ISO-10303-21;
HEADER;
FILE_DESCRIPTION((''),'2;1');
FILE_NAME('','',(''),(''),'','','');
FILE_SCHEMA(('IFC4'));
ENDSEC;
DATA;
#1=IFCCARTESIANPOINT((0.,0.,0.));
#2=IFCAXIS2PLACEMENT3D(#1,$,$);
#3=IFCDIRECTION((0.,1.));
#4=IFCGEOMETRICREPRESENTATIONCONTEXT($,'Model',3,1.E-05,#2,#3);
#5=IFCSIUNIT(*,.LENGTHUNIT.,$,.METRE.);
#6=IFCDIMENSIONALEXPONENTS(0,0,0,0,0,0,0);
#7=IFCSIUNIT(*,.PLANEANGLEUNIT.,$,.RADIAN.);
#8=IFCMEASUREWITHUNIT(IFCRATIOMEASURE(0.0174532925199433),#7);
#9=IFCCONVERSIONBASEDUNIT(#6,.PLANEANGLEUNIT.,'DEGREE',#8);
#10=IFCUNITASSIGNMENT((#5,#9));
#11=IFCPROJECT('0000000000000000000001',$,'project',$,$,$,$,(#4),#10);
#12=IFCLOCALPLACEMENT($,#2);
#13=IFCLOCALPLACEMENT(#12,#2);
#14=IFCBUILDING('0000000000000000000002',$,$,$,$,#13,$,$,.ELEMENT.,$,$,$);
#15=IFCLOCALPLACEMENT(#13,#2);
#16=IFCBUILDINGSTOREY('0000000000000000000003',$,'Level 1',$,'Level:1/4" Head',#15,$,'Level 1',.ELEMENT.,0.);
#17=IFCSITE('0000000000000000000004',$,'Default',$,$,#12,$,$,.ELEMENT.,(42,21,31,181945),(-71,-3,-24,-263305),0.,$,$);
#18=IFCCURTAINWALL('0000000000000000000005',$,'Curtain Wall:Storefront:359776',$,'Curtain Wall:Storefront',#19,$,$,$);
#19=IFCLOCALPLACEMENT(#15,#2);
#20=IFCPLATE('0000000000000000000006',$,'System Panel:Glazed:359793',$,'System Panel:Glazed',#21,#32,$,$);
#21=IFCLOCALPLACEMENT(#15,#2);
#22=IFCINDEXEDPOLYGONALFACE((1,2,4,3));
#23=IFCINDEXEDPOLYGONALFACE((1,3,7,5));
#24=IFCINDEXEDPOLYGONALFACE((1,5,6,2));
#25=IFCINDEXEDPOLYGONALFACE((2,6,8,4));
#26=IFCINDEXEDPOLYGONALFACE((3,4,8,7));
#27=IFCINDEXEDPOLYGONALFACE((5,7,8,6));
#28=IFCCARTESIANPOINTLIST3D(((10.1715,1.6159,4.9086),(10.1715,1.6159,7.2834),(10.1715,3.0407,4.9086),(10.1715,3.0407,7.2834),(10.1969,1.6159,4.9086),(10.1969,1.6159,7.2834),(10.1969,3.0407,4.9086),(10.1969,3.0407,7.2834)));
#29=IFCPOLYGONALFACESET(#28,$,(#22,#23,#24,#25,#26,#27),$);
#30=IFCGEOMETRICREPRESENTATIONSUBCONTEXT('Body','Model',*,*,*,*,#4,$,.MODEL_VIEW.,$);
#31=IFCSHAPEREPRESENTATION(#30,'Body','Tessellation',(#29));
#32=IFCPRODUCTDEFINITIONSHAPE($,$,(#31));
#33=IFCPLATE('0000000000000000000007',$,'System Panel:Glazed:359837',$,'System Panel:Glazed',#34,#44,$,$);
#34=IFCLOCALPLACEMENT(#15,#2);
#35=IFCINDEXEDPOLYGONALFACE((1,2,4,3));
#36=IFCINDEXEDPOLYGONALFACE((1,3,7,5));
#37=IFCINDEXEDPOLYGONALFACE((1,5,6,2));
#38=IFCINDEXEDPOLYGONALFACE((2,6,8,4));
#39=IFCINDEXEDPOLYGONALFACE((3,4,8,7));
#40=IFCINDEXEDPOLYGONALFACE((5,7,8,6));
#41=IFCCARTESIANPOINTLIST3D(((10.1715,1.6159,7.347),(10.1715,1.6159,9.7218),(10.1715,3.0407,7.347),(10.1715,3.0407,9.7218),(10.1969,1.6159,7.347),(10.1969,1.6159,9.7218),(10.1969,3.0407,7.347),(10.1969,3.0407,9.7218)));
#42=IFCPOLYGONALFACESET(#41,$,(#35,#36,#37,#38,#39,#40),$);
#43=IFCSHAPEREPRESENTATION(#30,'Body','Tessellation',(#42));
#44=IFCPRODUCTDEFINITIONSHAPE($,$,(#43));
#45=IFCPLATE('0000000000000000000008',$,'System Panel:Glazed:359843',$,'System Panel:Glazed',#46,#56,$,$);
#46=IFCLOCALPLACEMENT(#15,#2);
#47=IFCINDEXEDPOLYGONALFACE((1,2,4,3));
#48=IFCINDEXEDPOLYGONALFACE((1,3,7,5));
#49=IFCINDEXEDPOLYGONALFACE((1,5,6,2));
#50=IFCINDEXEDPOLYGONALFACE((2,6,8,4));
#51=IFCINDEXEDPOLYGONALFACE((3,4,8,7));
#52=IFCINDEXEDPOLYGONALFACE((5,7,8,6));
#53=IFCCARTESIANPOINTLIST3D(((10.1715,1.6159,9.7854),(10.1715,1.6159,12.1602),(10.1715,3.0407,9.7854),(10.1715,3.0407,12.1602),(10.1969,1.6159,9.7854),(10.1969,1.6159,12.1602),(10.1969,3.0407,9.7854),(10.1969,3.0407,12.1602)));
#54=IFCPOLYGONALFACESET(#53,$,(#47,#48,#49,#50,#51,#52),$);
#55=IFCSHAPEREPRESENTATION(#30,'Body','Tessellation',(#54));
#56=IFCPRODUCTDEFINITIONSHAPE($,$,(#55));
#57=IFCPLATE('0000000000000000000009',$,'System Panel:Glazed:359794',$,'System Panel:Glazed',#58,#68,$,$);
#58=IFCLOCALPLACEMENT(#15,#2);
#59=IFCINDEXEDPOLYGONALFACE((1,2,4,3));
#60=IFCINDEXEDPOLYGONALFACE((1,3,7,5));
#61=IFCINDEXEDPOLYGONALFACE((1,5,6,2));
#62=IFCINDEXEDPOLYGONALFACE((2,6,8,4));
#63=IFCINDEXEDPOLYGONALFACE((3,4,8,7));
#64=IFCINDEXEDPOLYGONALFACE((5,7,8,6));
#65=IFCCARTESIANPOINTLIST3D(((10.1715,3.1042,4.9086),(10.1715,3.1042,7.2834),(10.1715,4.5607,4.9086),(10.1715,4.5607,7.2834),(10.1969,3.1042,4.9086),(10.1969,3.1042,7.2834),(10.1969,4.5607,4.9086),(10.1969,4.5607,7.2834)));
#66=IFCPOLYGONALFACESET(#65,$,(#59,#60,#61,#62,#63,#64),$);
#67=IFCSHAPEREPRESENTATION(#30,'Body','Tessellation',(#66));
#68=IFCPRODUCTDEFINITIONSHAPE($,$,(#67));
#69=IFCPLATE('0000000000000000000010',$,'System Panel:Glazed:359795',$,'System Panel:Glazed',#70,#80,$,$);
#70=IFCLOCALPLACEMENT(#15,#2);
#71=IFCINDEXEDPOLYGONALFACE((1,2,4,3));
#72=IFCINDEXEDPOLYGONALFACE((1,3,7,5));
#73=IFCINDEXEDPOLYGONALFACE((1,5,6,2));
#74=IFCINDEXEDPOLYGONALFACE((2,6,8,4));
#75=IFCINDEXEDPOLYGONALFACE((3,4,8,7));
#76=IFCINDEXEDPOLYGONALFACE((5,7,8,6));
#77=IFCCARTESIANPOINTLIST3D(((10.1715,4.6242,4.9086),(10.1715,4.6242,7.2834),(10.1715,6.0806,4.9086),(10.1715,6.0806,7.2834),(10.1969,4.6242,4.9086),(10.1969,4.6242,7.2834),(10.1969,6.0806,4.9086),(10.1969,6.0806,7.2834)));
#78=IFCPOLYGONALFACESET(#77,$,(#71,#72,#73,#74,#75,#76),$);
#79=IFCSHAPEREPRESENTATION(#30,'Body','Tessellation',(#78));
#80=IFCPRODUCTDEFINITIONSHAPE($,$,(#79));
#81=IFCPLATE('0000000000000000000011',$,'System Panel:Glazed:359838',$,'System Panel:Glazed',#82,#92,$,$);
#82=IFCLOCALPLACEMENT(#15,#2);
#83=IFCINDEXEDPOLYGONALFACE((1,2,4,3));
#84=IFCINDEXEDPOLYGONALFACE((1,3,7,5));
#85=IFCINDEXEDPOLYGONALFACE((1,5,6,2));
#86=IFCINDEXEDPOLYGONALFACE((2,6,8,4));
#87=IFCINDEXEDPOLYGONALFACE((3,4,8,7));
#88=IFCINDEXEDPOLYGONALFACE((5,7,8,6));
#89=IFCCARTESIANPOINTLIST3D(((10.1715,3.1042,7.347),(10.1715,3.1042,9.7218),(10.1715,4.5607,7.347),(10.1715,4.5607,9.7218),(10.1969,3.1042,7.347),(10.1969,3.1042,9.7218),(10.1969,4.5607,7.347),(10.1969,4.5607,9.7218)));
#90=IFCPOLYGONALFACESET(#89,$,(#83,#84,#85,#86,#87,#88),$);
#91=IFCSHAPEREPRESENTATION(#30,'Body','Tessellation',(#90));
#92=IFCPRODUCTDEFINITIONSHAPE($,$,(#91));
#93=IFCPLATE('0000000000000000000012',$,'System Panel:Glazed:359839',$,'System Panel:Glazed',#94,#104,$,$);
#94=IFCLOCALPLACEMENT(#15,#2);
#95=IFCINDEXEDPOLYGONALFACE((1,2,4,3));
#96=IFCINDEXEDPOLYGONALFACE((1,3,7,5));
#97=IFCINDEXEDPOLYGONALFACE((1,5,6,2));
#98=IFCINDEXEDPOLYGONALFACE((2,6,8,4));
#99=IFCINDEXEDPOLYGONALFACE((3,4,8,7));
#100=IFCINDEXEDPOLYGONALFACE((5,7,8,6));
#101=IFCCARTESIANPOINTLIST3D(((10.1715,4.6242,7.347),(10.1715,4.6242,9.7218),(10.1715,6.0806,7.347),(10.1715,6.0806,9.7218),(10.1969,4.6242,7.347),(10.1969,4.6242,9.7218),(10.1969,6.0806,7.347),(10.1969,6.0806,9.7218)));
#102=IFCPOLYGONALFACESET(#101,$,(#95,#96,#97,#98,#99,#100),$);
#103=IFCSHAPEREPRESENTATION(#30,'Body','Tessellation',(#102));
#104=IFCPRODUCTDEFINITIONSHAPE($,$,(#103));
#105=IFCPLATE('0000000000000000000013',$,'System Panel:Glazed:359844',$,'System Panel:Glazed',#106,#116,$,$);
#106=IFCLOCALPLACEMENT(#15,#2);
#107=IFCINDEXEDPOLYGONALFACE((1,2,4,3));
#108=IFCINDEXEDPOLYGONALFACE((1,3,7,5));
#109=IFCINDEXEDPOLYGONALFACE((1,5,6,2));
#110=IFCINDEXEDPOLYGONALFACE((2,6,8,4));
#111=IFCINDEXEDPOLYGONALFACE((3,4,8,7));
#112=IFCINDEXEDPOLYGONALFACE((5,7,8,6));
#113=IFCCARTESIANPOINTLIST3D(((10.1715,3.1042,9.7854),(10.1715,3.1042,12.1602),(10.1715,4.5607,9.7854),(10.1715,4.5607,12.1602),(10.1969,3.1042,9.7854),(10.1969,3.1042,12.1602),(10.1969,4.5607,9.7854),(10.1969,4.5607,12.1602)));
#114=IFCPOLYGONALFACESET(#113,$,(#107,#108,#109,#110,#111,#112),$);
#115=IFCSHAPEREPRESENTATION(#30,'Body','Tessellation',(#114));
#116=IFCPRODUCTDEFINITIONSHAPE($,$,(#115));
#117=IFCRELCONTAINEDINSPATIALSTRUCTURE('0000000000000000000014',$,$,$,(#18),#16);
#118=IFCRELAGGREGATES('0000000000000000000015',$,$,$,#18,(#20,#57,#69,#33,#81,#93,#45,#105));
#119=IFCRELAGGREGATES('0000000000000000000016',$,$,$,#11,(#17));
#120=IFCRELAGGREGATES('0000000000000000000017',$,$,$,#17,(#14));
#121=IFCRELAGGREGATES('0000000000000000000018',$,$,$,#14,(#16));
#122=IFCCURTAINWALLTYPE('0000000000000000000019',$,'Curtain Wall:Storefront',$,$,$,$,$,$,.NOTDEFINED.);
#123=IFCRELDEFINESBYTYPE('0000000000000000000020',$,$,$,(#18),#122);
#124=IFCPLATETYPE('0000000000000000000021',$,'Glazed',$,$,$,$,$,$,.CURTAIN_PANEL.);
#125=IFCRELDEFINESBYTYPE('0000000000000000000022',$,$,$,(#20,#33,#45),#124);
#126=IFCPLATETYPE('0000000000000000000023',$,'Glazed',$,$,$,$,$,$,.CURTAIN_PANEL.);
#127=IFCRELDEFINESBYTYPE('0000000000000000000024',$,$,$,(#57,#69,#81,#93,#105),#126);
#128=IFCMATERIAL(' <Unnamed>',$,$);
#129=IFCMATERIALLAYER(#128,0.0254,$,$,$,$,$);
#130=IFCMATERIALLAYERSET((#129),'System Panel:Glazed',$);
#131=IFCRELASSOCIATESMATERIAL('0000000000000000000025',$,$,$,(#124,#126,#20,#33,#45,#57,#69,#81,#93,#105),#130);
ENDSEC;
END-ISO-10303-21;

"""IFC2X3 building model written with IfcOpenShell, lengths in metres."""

from ifc_helpers import new_model, entity, si_unit, converted_unit, direction, frame, frame_2d, origin, origin_2d_with_axis, place, context, subcontext, project, spatial, rectangle, extrude, source, transform, mapped, material, layer, layer_set, layer_usage, type_object, type_shapes, element, aggregate, save


model = new_model("IFC2X3")

# Units and contexts
model_context = context("Model", 3, precision=1e-05, world=origin(), true_north=direction((0.0, 1.0)))
body_context = subcontext(model_context, "Body", "Model", "MODEL_VIEW")
ifc_project = project(units=[si_unit("LENGTHUNIT", "METRE"), converted_unit("PLANEANGLEUNIT", "DEGREE", entity("IfcRatioMeasure", 0.0174532925199433), si_unit("PLANEANGLEUNIT", "RADIAN"), dimensions=[0, 0, 0, 0, 0, 0, 0])], contexts=[model_context])

# Site, building, storey
site_placement = place(None, origin())
site = spatial("IfcSite", under=ifc_project, at=site_placement, Name="Default", CompositionType="ELEMENT", RefLatitude=(42, 21, 31, 181945), RefLongitude=(-71, -3, -24, -263305), RefElevation=0.0)
building_placement = place(site_placement, origin())
building = spatial("IfcBuilding", under=site, at=building_placement, CompositionType="ELEMENT")
storey_placement = place(building_placement, origin())
storey = spatial("IfcBuildingStorey", under=building, at=storey_placement, Name="Level 1", ObjectType="Level:1/4\" Head", LongName="Level 1", CompositionType="ELEMENT", Elevation=0.0)

# Shared definitions
curtain_wall_type = type_object("IfcCurtainWallType", Name="Curtain Wall:Storefront", PredefinedType="NOTDEFINED")

# Curtain wall, plates
curtain_wall_1_placement = place(storey_placement, origin())
curtain_wall_1 = element("IfcCurtainWall", 1, at=curtain_wall_1_placement, inside=storey, type_object=curtain_wall_type, Name="Curtain Wall:Storefront:359776", ObjectType="Curtain Wall:Storefront")
ifc_material_1 = material(Name=" <Unnamed>")
ifc_layer = layer(ifc_material_1, 0.0254)
ifc_layer_set = layer_set([ifc_layer], Name="System Panel:Glazed")
ifc_layer_usage_1 = layer_usage(ifc_layer_set, "AXIS3", "POSITIVE", 0.1042)
plate_type_1 = type_object("IfcPlateType", Name="Glazed", PredefinedType="CURTAIN_PANEL", material=ifc_layer_set)
shared_shape_1 = source(origin(), body_context, "Body", "SweptSolid", [
    extrude(rectangle(XDim=0.0254, YDim=1.4248, at=frame_2d((0.0, 0.0), x_axis=(1.0, 0.0))), frame((0.7124, 0.0127, 0.0), z_axis=(0.0, 0.0, 1.0), x_axis=(0.0, 1.0, 0.0)), (0.0, 0.0, 1.0), 2.3749),
])
type_shapes(plate_type_1, [shared_shape_1])
plate_1_placement = place(curtain_wall_1_placement, frame((10.1969, 1.6159, 4.9085), z_axis=(0.0, 0.0, 1.0), x_axis=(0.0, 1.0, 0.0)))
plate_1 = element("IfcPlate", 2, at=plate_1_placement, type_object=plate_type_1, material=ifc_layer_usage_1, Name="System Panel:Glazed:359793", ObjectType="System Panel:Glazed", context=body_context, shape_type="MappedRepresentation", body=[
    mapped(shared_shape_1, transform((0.0, 0.0, 0.0), scale=1.0)),
])
ifc_layer_usage_2 = layer_usage(ifc_layer_set, "AXIS3", "POSITIVE", 0.1042)
plate_2_placement = place(curtain_wall_1_placement, frame((10.1969, 1.6159, 7.3469), z_axis=(0.0, 0.0, 1.0), x_axis=(0.0, 1.0, 0.0)))
plate_2 = element("IfcPlate", 3, at=plate_2_placement, type_object=plate_type_1, material=ifc_layer_usage_2, Name="System Panel:Glazed:359837", ObjectType="System Panel:Glazed", context=body_context, shape_type="MappedRepresentation", body=[
    mapped(shared_shape_1, transform((0.0, 0.0, 0.0), scale=1.0)),
])
ifc_layer_usage_3 = layer_usage(ifc_layer_set, "AXIS3", "POSITIVE", 0.1042)
plate_3_placement = place(curtain_wall_1_placement, frame((10.1969, 1.6159, 9.7853), z_axis=(0.0, 0.0, 1.0), x_axis=(0.0, 1.0, 0.0)))
plate_3 = element("IfcPlate", 4, at=plate_3_placement, type_object=plate_type_1, material=ifc_layer_usage_3, Name="System Panel:Glazed:359843", ObjectType="System Panel:Glazed", context=body_context, shape_type="MappedRepresentation", body=[
    mapped(shared_shape_1, transform((0.0, 0.0, 0.0), scale=1.0)),
])
ifc_layer_usage_4 = layer_usage(ifc_layer_set, "AXIS3", "POSITIVE", 0.1042)
plate_type_2 = type_object("IfcPlateType", Name="Glazed", PredefinedType="CURTAIN_PANEL", material=ifc_layer_set)
shared_shape_2 = source(origin(), body_context, "Body", "SweptSolid", [
    extrude(rectangle(XDim=0.0254, YDim=1.4565, at=origin_2d_with_axis()), frame((0.7282, 0.0127, 0.0), z_axis=(0.0, 0.0, 1.0), x_axis=(0.0, 1.0, 0.0)), (0.0, 0.0, 1.0), 2.3749),
])
type_shapes(plate_type_2, [shared_shape_2])
plate_4_placement = place(curtain_wall_1_placement, frame((10.1969, 3.1042, 4.9085), z_axis=(0.0, 0.0, 1.0), x_axis=(0.0, 1.0, 0.0)))
plate_4 = element("IfcPlate", 5, at=plate_4_placement, type_object=plate_type_2, material=ifc_layer_usage_4, Name="System Panel:Glazed:359794", ObjectType="System Panel:Glazed", context=body_context, shape_type="MappedRepresentation", body=[
    mapped(shared_shape_2, transform((0.0, 0.0, 0.0), scale=1.0)),
])
ifc_layer_usage_5 = layer_usage(ifc_layer_set, "AXIS3", "POSITIVE", 0.1042)
plate_5_placement = place(curtain_wall_1_placement, frame((10.1969, 4.6242, 4.9085), z_axis=(0.0, 0.0, 1.0), x_axis=(0.0, 1.0, 0.0)))
plate_5 = element("IfcPlate", 6, at=plate_5_placement, type_object=plate_type_2, material=ifc_layer_usage_5, Name="System Panel:Glazed:359795", ObjectType="System Panel:Glazed", context=body_context, shape_type="MappedRepresentation", body=[
    mapped(shared_shape_2, transform((0.0, 0.0, 0.0), scale=1.0)),
])
ifc_layer_usage_6 = layer_usage(ifc_layer_set, "AXIS3", "POSITIVE", 0.1042)
plate_6_placement = place(curtain_wall_1_placement, frame((10.1969, 3.1042, 7.3469), z_axis=(0.0, 0.0, 1.0), x_axis=(0.0, 1.0, 0.0)))
plate_6 = element("IfcPlate", 7, at=plate_6_placement, type_object=plate_type_2, material=ifc_layer_usage_6, Name="System Panel:Glazed:359838", ObjectType="System Panel:Glazed", context=body_context, shape_type="MappedRepresentation", body=[
    mapped(shared_shape_2, transform((0.0, 0.0, 0.0), scale=1.0)),
])
ifc_layer_usage_7 = layer_usage(ifc_layer_set, "AXIS3", "POSITIVE", 0.1042)
plate_7_placement = place(curtain_wall_1_placement, frame((10.1969, 4.6242, 7.3469), z_axis=(0.0, 0.0, 1.0), x_axis=(0.0, 1.0, 0.0)))
plate_7 = element("IfcPlate", 8, at=plate_7_placement, type_object=plate_type_2, material=ifc_layer_usage_7, Name="System Panel:Glazed:359839", ObjectType="System Panel:Glazed", context=body_context, shape_type="MappedRepresentation", body=[
    mapped(shared_shape_2, transform((0.0, 0.0, 0.0), scale=1.0)),
])
ifc_layer_usage_8 = layer_usage(ifc_layer_set, "AXIS3", "POSITIVE", 0.1042)
plate_8_placement = place(curtain_wall_1_placement, frame((10.1969, 3.1042, 9.7853), z_axis=(0.0, 0.0, 1.0), x_axis=(0.0, 1.0, 0.0)))
plate_8 = element("IfcPlate", 9, at=plate_8_placement, type_object=plate_type_2, material=ifc_layer_usage_8, Name="System Panel:Glazed:359844", ObjectType="System Panel:Glazed", context=body_context, shape_type="MappedRepresentation", body=[
    mapped(shared_shape_2, transform((0.0, 0.0, 0.0), scale=1.0)),
])
aggregate(curtain_wall_1, [plate_1, plate_4, plate_5, plate_2, plate_6, plate_7, plate_3, plate_8])

save(model, "model.ifc")
